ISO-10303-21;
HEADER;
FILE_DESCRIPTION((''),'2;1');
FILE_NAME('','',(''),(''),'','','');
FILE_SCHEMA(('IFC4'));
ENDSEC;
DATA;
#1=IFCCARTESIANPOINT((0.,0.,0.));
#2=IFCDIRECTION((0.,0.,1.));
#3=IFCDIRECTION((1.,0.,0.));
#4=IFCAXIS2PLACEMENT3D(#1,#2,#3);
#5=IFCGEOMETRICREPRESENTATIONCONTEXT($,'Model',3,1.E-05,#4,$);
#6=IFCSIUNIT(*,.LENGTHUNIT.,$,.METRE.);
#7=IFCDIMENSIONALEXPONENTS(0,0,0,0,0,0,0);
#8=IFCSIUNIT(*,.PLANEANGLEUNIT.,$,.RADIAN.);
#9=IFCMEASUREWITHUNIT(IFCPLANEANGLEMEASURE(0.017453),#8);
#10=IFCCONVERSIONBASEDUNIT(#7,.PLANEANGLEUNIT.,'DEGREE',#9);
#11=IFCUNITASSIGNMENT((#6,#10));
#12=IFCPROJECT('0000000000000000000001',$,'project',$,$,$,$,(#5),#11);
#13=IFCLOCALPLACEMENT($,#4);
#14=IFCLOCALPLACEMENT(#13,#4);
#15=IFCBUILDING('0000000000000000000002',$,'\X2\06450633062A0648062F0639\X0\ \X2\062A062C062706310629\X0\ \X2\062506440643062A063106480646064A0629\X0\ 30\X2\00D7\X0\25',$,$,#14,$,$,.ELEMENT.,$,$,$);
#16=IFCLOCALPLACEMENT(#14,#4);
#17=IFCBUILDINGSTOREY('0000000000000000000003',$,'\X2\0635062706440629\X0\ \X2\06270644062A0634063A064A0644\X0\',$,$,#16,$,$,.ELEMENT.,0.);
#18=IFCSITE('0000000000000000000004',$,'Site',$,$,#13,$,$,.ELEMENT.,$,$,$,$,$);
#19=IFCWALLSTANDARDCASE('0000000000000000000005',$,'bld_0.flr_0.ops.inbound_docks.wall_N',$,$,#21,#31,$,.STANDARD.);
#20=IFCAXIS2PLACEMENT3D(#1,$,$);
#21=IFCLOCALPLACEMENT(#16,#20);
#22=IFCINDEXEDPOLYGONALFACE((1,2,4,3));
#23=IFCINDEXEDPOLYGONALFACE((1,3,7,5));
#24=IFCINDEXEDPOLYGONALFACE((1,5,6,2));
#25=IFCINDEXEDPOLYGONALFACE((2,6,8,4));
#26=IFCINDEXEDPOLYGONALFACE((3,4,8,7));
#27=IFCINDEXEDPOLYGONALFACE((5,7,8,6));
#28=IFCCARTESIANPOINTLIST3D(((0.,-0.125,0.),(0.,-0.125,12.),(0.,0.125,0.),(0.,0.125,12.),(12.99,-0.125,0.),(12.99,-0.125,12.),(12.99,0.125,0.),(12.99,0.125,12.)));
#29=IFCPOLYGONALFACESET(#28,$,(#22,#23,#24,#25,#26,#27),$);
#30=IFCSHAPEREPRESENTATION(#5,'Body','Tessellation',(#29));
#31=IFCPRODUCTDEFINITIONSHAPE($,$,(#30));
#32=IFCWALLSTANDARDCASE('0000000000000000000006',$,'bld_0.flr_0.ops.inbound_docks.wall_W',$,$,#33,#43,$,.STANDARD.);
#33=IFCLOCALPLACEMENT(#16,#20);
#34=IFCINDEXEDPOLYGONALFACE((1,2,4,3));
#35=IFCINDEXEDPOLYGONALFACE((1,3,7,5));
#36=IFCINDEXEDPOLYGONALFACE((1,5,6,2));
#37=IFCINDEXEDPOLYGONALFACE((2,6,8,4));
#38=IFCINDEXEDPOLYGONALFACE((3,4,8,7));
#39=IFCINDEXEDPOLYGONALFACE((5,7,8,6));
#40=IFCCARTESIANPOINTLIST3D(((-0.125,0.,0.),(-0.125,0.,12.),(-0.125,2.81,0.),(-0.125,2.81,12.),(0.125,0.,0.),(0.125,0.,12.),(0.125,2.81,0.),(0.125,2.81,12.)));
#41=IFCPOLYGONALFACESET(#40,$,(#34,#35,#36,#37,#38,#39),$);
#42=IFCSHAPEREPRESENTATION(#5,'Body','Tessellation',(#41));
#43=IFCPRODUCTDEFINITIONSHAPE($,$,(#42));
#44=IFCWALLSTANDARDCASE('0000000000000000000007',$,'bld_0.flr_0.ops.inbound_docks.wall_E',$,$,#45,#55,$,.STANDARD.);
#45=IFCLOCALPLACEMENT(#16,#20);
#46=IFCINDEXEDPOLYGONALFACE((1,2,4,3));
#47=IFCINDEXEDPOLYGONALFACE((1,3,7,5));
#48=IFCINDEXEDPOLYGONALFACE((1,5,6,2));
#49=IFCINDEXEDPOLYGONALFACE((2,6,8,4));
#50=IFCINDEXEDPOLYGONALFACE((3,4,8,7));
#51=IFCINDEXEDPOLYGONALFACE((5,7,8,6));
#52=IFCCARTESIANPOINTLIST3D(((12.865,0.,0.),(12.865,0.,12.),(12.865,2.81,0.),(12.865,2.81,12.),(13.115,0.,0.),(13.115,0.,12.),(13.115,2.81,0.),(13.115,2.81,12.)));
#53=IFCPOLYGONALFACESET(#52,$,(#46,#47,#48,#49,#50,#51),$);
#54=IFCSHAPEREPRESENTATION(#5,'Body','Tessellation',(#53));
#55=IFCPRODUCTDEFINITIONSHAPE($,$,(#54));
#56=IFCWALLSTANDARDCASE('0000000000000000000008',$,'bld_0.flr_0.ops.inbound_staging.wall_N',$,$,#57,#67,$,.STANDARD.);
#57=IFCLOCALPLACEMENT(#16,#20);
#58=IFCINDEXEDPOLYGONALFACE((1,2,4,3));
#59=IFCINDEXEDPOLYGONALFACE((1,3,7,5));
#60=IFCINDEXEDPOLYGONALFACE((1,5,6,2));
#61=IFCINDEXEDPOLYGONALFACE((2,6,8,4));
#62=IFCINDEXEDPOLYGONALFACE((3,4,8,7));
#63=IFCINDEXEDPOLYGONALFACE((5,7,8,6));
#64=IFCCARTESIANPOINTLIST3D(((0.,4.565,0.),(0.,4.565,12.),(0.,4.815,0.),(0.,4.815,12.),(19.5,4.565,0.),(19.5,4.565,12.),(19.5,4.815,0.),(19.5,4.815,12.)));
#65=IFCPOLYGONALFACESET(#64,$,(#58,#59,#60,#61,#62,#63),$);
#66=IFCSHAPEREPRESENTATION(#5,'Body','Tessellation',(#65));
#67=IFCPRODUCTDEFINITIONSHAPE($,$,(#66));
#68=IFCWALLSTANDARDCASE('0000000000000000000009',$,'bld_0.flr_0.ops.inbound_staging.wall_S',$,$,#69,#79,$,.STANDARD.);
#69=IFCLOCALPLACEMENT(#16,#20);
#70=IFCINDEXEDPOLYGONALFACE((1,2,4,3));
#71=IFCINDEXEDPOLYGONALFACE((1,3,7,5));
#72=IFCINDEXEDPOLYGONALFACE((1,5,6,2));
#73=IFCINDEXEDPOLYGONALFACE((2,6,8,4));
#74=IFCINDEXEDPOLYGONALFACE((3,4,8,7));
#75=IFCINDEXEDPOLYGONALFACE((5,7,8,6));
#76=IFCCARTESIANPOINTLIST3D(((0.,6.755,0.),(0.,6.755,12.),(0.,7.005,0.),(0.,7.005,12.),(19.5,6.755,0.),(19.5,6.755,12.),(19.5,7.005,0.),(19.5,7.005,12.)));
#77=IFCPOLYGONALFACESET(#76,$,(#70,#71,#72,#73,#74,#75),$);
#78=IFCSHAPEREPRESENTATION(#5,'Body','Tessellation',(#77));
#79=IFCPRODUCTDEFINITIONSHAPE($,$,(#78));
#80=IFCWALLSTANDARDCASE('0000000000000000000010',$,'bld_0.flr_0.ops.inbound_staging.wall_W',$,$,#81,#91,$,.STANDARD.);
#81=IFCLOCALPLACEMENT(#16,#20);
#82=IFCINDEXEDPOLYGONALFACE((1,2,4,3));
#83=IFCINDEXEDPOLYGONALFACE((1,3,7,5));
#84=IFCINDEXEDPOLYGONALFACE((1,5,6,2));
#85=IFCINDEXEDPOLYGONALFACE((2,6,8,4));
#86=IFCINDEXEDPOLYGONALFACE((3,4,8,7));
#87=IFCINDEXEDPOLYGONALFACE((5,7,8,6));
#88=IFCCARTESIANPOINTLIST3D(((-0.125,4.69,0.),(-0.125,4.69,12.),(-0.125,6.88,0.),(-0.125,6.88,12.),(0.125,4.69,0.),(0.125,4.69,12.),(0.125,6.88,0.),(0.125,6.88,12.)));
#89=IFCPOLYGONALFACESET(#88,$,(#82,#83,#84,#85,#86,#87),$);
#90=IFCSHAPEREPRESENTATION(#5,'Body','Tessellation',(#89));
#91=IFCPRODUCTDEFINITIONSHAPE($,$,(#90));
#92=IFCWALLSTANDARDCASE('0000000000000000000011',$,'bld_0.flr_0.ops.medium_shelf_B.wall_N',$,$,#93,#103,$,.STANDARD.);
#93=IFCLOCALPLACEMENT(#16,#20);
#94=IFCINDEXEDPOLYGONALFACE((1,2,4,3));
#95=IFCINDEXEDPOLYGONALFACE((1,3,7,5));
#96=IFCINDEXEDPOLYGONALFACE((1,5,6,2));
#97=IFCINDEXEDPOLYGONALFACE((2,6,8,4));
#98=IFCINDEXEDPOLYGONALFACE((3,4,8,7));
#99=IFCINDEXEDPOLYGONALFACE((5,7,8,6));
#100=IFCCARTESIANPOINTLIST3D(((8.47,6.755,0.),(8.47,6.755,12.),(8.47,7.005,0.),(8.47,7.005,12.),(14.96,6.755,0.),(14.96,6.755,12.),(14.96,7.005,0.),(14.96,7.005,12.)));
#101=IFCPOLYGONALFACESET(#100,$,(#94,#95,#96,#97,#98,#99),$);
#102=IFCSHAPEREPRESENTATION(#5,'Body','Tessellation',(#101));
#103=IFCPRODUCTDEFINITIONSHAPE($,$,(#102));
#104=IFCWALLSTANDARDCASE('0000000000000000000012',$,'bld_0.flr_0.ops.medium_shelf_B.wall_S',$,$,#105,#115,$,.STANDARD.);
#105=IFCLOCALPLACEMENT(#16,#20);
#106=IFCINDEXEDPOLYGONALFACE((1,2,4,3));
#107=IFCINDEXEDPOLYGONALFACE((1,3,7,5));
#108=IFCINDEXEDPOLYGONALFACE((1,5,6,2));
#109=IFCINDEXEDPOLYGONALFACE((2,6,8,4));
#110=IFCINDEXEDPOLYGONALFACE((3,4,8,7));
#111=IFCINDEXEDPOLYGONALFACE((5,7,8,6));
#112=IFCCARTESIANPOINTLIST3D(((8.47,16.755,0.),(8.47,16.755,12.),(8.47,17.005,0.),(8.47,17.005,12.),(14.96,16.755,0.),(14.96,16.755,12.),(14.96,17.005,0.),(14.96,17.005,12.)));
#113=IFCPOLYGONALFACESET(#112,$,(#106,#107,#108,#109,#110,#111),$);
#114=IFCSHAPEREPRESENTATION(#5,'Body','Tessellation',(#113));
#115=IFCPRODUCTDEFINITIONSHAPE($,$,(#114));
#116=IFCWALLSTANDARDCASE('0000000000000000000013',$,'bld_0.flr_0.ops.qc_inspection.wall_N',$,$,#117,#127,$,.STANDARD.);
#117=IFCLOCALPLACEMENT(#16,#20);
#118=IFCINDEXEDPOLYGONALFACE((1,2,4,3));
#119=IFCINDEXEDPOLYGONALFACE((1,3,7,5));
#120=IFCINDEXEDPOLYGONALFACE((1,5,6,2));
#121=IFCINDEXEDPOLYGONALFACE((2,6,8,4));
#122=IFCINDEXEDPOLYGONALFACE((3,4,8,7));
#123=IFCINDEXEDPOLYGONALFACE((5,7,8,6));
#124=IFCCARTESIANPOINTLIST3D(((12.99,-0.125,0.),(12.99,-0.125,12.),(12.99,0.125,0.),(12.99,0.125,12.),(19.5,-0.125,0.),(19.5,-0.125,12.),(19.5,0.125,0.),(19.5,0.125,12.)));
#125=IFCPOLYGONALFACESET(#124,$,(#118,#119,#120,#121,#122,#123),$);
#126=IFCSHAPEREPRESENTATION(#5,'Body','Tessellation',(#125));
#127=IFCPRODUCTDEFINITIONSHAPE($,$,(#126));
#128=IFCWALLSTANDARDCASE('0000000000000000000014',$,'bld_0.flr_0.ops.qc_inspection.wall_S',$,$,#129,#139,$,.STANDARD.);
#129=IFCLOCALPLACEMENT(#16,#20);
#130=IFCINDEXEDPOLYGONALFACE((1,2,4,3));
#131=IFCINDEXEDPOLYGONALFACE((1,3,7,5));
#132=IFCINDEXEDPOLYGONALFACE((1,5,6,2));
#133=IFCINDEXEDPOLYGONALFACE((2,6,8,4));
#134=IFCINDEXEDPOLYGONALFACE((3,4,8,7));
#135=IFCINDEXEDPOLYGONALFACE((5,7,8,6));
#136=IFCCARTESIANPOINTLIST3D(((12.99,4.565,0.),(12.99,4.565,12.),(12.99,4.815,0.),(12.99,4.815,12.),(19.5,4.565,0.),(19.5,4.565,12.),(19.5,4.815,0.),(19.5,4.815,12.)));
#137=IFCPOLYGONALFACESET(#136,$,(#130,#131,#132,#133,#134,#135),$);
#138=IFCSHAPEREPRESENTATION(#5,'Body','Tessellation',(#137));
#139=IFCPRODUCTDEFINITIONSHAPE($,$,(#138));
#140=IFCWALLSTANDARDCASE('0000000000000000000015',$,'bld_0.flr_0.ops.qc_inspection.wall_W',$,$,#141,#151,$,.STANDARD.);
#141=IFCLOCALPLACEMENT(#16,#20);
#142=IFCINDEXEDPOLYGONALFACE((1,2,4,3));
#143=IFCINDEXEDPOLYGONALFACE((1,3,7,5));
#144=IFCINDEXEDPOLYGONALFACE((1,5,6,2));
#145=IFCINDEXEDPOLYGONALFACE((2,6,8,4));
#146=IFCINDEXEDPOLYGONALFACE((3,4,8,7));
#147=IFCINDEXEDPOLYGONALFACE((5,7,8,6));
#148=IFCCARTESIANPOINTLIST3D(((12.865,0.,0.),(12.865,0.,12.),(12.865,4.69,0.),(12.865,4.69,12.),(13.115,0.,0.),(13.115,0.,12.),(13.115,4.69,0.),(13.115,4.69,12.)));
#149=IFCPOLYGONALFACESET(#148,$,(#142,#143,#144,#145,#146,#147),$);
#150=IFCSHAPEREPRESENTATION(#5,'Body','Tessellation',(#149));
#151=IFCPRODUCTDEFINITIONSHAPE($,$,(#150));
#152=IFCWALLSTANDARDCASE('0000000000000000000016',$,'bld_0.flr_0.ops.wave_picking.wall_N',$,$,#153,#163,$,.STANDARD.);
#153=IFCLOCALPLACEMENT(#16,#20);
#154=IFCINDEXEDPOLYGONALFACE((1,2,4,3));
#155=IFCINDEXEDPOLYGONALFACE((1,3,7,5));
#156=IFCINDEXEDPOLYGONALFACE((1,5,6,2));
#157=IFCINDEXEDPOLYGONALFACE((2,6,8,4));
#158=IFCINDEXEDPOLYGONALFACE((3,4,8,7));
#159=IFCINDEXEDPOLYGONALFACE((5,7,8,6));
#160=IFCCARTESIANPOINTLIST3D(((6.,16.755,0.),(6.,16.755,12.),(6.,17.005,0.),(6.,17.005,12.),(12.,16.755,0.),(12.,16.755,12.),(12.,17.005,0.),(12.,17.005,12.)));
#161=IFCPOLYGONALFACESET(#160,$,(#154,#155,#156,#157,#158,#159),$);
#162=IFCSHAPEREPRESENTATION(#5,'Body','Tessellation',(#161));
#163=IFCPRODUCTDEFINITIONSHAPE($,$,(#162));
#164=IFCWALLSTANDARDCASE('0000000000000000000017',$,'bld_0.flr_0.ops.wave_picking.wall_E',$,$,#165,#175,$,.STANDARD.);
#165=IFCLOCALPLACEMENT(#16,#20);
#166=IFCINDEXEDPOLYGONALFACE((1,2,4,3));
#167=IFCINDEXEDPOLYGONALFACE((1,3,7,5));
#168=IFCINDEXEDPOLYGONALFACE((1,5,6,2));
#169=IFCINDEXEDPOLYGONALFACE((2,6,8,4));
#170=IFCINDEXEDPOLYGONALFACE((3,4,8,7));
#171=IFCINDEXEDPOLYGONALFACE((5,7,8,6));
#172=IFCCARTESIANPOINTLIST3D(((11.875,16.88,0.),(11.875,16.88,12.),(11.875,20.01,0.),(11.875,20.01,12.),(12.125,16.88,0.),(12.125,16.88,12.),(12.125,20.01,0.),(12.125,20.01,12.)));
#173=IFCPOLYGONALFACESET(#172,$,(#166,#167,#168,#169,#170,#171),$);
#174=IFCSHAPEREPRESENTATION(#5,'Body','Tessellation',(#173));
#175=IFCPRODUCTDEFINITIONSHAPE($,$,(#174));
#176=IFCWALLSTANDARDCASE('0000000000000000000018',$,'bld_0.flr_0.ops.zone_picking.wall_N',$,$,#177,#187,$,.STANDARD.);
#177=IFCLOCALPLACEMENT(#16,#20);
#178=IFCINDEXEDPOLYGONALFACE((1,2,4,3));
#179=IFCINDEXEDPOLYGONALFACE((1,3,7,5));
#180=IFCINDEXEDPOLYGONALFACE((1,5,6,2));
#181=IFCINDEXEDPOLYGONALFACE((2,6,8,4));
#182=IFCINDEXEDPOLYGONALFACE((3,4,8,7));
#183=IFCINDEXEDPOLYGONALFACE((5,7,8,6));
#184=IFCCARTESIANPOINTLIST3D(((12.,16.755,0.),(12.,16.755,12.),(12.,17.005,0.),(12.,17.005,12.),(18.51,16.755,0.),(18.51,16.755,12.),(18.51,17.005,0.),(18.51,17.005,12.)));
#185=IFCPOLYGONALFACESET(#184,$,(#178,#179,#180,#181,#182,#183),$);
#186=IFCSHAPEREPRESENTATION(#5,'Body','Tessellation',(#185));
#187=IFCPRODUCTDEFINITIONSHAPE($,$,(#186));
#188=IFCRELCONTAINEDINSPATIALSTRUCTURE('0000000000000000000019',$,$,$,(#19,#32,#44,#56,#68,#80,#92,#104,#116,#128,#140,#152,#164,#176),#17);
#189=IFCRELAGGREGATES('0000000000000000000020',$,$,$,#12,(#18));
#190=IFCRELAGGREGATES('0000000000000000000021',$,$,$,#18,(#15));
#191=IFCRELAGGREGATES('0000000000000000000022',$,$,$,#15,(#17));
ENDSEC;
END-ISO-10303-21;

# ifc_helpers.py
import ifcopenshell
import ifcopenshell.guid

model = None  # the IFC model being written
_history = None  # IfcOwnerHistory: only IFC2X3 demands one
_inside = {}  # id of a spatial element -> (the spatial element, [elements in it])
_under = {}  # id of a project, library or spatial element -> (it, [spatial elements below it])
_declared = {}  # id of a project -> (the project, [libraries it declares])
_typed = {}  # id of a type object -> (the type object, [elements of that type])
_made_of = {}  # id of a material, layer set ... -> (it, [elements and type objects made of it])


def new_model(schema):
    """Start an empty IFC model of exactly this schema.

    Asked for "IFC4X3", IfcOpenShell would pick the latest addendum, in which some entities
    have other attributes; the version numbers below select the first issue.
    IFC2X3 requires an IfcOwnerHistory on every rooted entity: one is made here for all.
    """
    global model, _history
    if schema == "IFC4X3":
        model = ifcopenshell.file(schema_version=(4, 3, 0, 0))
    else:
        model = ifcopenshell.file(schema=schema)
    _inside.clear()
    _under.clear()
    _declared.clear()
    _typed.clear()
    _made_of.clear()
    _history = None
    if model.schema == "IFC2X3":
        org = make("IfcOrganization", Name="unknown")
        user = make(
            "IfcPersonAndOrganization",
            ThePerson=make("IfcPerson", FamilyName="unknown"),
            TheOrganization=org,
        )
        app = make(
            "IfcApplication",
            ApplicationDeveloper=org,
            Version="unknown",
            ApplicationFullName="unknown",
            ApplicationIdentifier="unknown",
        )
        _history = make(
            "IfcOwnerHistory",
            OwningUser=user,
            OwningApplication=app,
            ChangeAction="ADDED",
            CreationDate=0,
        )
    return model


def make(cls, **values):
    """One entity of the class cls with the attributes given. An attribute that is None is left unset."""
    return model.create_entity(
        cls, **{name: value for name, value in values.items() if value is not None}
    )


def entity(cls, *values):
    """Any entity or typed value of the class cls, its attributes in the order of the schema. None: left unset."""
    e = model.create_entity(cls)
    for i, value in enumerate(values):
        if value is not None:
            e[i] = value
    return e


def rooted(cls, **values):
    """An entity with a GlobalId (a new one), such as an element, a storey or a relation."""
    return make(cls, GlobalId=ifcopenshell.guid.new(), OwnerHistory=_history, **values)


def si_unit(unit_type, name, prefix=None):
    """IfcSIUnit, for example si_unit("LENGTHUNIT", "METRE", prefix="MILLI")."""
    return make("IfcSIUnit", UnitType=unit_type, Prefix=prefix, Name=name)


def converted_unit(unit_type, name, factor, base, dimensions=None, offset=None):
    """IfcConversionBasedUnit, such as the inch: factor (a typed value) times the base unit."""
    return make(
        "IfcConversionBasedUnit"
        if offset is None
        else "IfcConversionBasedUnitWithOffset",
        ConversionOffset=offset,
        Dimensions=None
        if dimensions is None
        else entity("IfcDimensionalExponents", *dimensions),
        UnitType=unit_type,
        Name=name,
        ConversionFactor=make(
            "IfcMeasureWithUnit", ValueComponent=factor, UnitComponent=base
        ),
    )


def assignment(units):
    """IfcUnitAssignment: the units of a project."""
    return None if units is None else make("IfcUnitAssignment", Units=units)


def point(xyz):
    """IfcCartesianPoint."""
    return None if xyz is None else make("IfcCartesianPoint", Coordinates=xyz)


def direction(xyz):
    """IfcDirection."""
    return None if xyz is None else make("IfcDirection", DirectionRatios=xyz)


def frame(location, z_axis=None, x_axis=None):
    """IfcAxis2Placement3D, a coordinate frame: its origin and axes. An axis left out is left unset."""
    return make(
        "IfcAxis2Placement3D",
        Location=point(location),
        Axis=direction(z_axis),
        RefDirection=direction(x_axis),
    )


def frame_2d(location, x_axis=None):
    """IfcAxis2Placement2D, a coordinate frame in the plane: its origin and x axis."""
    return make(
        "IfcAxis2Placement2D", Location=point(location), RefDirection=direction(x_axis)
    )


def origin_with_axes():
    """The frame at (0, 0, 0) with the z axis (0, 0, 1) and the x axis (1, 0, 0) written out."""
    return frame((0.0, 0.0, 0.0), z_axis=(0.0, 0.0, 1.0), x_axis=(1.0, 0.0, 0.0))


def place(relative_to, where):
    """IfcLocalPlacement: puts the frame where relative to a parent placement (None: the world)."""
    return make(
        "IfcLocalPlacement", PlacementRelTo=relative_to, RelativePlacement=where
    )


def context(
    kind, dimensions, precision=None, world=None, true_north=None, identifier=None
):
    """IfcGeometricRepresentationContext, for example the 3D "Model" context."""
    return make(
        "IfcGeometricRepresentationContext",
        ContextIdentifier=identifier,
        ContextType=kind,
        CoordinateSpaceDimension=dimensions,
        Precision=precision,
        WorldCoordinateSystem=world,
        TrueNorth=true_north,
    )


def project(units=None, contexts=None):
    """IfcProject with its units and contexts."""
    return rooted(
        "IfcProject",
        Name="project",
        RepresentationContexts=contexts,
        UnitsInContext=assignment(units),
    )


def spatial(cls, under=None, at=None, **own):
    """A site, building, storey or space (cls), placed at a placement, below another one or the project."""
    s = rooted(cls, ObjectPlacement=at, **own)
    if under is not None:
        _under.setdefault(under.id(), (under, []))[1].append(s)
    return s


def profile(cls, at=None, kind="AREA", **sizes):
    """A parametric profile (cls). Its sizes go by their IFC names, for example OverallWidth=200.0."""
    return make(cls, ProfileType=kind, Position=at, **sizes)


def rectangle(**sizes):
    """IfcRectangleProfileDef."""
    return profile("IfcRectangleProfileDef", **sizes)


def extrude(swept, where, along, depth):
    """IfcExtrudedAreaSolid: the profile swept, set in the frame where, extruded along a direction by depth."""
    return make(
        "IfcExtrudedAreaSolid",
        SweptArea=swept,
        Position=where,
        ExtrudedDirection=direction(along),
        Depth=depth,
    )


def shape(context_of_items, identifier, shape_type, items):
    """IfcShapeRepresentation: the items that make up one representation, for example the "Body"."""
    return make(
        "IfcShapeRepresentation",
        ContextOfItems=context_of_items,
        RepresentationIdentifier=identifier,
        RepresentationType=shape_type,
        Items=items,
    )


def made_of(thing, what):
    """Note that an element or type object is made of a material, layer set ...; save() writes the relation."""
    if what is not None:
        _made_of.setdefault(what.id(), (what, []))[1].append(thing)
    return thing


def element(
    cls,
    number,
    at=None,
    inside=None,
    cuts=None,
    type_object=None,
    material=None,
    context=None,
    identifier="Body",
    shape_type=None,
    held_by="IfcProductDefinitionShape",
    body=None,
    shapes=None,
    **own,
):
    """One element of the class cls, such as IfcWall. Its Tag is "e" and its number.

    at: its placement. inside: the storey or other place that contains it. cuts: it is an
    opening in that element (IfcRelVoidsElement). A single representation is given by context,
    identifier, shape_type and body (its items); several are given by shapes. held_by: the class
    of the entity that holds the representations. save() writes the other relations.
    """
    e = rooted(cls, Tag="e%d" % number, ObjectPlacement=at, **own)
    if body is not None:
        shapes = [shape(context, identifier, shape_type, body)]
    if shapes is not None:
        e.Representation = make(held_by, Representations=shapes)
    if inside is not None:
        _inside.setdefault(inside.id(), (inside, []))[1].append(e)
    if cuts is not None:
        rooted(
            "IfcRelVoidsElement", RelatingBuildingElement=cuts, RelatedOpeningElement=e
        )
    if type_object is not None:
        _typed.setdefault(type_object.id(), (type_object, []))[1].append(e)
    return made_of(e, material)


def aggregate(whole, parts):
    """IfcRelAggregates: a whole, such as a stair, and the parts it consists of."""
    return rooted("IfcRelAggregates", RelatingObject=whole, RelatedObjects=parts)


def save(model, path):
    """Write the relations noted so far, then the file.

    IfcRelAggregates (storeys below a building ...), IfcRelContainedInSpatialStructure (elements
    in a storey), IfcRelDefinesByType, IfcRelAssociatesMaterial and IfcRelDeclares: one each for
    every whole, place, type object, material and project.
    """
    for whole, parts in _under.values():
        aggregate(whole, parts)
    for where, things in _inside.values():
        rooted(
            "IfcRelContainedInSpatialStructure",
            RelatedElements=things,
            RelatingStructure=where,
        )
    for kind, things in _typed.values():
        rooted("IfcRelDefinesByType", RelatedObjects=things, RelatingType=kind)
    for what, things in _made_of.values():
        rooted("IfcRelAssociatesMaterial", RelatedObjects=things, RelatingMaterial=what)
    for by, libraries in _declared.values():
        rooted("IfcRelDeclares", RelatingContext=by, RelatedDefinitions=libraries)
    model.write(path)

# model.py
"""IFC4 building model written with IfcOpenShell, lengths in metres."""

from ifc_helpers import new_model, entity, si_unit, converted_unit, frame, frame_2d, origin_with_axes, place, context, project, spatial, rectangle, extrude, element, save


model = new_model("IFC4")

# Units and contexts
model_context = context("Model", 3, precision=1e-05, world=origin_with_axes())
ifc_project = project(units=[si_unit("LENGTHUNIT", "METRE"), converted_unit("PLANEANGLEUNIT", "DEGREE", entity("IfcPlaneAngleMeasure", 0.017453), si_unit("PLANEANGLEUNIT", "RADIAN"), dimensions=[0, 0, 0, 0, 0, 0, 0])], contexts=[model_context])

# Site, building, storey
site_placement = place(None, origin_with_axes())
site = spatial("IfcSite", under=ifc_project, at=site_placement, Name="Site", CompositionType="ELEMENT")
building_placement = place(site_placement, origin_with_axes())
building = spatial("IfcBuilding", under=site, at=building_placement, Name="مستودع تجارة إلكترونية 30×25", CompositionType="ELEMENT")
storey_placement = place(building_placement, origin_with_axes())
storey = spatial("IfcBuildingStorey", under=building, at=storey_placement, Name="صالة التشغيل", CompositionType="ELEMENT", Elevation=0.0)

# Walls
for number, where, z_axis, x_axis, name in (
    (1, (0.0, 0.0, 0.0), (0.0, 0.0, 1.0), (1.0, 0.0, 0.0), "bld_0.flr_0.ops.inbound_docks.wall_N"),
):
    element("IfcWallStandardCase", number, at=place(storey_placement, frame(where, z_axis=z_axis, x_axis=x_axis)), inside=storey, Name=name, PredefinedType="STANDARD", context=model_context, shape_type="SweptSolid", body=[
        extrude(rectangle(XDim=12.99, YDim=0.25, at=frame_2d((6.495, 0.0), x_axis=(1.0, 0.0))), origin_with_axes(), (0.0, 0.0, 1.0), 12.0),
    ])
for number, where, z_axis, x_axis, name in (
    (2, (0.0, 0.0, 0.0), (0.0, 0.0, 1.0), (0.0, 1.0, 0.0), "bld_0.flr_0.ops.inbound_docks.wall_W"),
    (3, (12.99, 0.0, 0.0), (0.0, 0.0, 1.0), (0.0, 1.0, 0.0), "bld_0.flr_0.ops.inbound_docks.wall_E"),
):
    element("IfcWallStandardCase", number, at=place(storey_placement, frame(where, z_axis=z_axis, x_axis=x_axis)), inside=storey, Name=name, PredefinedType="STANDARD", context=model_context, shape_type="SweptSolid", body=[
        extrude(rectangle(XDim=2.81, YDim=0.25, at=frame_2d((1.405, 0.0), x_axis=(1.0, 0.0))), origin_with_axes(), (0.0, 0.0, 1.0), 12.0),
    ])
for number, where, z_axis, x_axis, name in (
    (4, (0.0, 4.69, 0.0), (0.0, 0.0, 1.0), (1.0, 0.0, 0.0), "bld_0.flr_0.ops.inbound_staging.wall_N"),
    (5, (0.0, 6.88, 0.0), (0.0, 0.0, 1.0), (1.0, 0.0, 0.0), "bld_0.flr_0.ops.inbound_staging.wall_S"),
):
    element("IfcWallStandardCase", number, at=place(storey_placement, frame(where, z_axis=z_axis, x_axis=x_axis)), inside=storey, Name=name, PredefinedType="STANDARD", context=model_context, shape_type="SweptSolid", body=[
        extrude(rectangle(XDim=19.5, YDim=0.25, at=frame_2d((9.75, 0.0), x_axis=(1.0, 0.0))), origin_with_axes(), (0.0, 0.0, 1.0), 12.0),
    ])
wall_1_placement = place(storey_placement, frame((0.0, 4.69, 0.0), z_axis=(0.0, 0.0, 1.0), x_axis=(0.0, 1.0, 0.0)))
element("IfcWallStandardCase", 6, at=wall_1_placement, inside=storey, Name="bld_0.flr_0.ops.inbound_staging.wall_W", PredefinedType="STANDARD", context=model_context, shape_type="SweptSolid", body=[
    extrude(rectangle(XDim=2.19, YDim=0.25, at=frame_2d((1.095, 0.0), x_axis=(1.0, 0.0))), origin_with_axes(), (0.0, 0.0, 1.0), 12.0),
])
for number, where, z_axis, x_axis, name in (
    (7, (8.47, 6.88, 0.0), (0.0, 0.0, 1.0), (1.0, 0.0, 0.0), "bld_0.flr_0.ops.medium_shelf_B.wall_N"),
    (8, (8.47, 16.88, 0.0), (0.0, 0.0, 1.0), (1.0, 0.0, 0.0), "bld_0.flr_0.ops.medium_shelf_B.wall_S"),
):
    element("IfcWallStandardCase", number, at=place(storey_placement, frame(where, z_axis=z_axis, x_axis=x_axis)), inside=storey, Name=name, PredefinedType="STANDARD", context=model_context, shape_type="SweptSolid", body=[
        extrude(rectangle(XDim=6.49, YDim=0.25, at=frame_2d((3.245, 0.0), x_axis=(1.0, 0.0))), origin_with_axes(), (0.0, 0.0, 1.0), 12.0),
    ])
for number, where, z_axis, x_axis, name in (
    (9, (12.99, 0.0, 0.0), (0.0, 0.0, 1.0), (1.0, 0.0, 0.0), "bld_0.flr_0.ops.qc_inspection.wall_N"),
    (10, (12.99, 4.69, 0.0), (0.0, 0.0, 1.0), (1.0, 0.0, 0.0), "bld_0.flr_0.ops.qc_inspection.wall_S"),
):
    element("IfcWallStandardCase", number, at=place(storey_placement, frame(where, z_axis=z_axis, x_axis=x_axis)), inside=storey, Name=name, PredefinedType="STANDARD", context=model_context, shape_type="SweptSolid", body=[
        extrude(rectangle(XDim=6.51, YDim=0.25, at=frame_2d((3.255, 0.0), x_axis=(1.0, 0.0))), origin_with_axes(), (0.0, 0.0, 1.0), 12.0),
    ])
wall_2_placement = place(storey_placement, frame((12.99, 0.0, 0.0), z_axis=(0.0, 0.0, 1.0), x_axis=(0.0, 1.0, 0.0)))
element("IfcWallStandardCase", 11, at=wall_2_placement, inside=storey, Name="bld_0.flr_0.ops.qc_inspection.wall_W", PredefinedType="STANDARD", context=model_context, shape_type="SweptSolid", body=[
    extrude(rectangle(XDim=4.69, YDim=0.25, at=frame_2d((2.345, 0.0), x_axis=(1.0, 0.0))), origin_with_axes(), (0.0, 0.0, 1.0), 12.0),
])
wall_3_placement = place(storey_placement, frame((6.0, 16.88, 0.0), z_axis=(0.0, 0.0, 1.0), x_axis=(1.0, 0.0, 0.0)))
element("IfcWallStandardCase", 12, at=wall_3_placement, inside=storey, Name="bld_0.flr_0.ops.wave_picking.wall_N", PredefinedType="STANDARD", context=model_context, shape_type="SweptSolid", body=[
    extrude(rectangle(XDim=6.0, YDim=0.25, at=frame_2d((3.0, 0.0), x_axis=(1.0, 0.0))), origin_with_axes(), (0.0, 0.0, 1.0), 12.0),
])
for number, where, z_axis, x_axis, name in (
    (13, (12.0, 16.88, 0.0), (0.0, 0.0, 1.0), (0.0, 1.0, 0.0), "bld_0.flr_0.ops.wave_picking.wall_E"),
):
    element("IfcWallStandardCase", number, at=place(storey_placement, frame(where, z_axis=z_axis, x_axis=x_axis)), inside=storey, Name=name, PredefinedType="STANDARD", context=model_context, shape_type="SweptSolid", body=[
        extrude(rectangle(XDim=3.13, YDim=0.25, at=frame_2d((1.565, 0.0), x_axis=(1.0, 0.0))), origin_with_axes(), (0.0, 0.0, 1.0), 12.0),
    ])
wall_4_placement = place(storey_placement, frame((12.0, 16.88, 0.0), z_axis=(0.0, 0.0, 1.0), x_axis=(1.0, 0.0, 0.0)))
element("IfcWallStandardCase", 14, at=wall_4_placement, inside=storey, Name="bld_0.flr_0.ops.zone_picking.wall_N", PredefinedType="STANDARD", context=model_context, shape_type="SweptSolid", body=[
    extrude(rectangle(XDim=6.51, YDim=0.25, at=frame_2d((3.255, 0.0), x_axis=(1.0, 0.0))), origin_with_axes(), (0.0, 0.0, 1.0), 12.0),
])

save(model, "model.ifc")
